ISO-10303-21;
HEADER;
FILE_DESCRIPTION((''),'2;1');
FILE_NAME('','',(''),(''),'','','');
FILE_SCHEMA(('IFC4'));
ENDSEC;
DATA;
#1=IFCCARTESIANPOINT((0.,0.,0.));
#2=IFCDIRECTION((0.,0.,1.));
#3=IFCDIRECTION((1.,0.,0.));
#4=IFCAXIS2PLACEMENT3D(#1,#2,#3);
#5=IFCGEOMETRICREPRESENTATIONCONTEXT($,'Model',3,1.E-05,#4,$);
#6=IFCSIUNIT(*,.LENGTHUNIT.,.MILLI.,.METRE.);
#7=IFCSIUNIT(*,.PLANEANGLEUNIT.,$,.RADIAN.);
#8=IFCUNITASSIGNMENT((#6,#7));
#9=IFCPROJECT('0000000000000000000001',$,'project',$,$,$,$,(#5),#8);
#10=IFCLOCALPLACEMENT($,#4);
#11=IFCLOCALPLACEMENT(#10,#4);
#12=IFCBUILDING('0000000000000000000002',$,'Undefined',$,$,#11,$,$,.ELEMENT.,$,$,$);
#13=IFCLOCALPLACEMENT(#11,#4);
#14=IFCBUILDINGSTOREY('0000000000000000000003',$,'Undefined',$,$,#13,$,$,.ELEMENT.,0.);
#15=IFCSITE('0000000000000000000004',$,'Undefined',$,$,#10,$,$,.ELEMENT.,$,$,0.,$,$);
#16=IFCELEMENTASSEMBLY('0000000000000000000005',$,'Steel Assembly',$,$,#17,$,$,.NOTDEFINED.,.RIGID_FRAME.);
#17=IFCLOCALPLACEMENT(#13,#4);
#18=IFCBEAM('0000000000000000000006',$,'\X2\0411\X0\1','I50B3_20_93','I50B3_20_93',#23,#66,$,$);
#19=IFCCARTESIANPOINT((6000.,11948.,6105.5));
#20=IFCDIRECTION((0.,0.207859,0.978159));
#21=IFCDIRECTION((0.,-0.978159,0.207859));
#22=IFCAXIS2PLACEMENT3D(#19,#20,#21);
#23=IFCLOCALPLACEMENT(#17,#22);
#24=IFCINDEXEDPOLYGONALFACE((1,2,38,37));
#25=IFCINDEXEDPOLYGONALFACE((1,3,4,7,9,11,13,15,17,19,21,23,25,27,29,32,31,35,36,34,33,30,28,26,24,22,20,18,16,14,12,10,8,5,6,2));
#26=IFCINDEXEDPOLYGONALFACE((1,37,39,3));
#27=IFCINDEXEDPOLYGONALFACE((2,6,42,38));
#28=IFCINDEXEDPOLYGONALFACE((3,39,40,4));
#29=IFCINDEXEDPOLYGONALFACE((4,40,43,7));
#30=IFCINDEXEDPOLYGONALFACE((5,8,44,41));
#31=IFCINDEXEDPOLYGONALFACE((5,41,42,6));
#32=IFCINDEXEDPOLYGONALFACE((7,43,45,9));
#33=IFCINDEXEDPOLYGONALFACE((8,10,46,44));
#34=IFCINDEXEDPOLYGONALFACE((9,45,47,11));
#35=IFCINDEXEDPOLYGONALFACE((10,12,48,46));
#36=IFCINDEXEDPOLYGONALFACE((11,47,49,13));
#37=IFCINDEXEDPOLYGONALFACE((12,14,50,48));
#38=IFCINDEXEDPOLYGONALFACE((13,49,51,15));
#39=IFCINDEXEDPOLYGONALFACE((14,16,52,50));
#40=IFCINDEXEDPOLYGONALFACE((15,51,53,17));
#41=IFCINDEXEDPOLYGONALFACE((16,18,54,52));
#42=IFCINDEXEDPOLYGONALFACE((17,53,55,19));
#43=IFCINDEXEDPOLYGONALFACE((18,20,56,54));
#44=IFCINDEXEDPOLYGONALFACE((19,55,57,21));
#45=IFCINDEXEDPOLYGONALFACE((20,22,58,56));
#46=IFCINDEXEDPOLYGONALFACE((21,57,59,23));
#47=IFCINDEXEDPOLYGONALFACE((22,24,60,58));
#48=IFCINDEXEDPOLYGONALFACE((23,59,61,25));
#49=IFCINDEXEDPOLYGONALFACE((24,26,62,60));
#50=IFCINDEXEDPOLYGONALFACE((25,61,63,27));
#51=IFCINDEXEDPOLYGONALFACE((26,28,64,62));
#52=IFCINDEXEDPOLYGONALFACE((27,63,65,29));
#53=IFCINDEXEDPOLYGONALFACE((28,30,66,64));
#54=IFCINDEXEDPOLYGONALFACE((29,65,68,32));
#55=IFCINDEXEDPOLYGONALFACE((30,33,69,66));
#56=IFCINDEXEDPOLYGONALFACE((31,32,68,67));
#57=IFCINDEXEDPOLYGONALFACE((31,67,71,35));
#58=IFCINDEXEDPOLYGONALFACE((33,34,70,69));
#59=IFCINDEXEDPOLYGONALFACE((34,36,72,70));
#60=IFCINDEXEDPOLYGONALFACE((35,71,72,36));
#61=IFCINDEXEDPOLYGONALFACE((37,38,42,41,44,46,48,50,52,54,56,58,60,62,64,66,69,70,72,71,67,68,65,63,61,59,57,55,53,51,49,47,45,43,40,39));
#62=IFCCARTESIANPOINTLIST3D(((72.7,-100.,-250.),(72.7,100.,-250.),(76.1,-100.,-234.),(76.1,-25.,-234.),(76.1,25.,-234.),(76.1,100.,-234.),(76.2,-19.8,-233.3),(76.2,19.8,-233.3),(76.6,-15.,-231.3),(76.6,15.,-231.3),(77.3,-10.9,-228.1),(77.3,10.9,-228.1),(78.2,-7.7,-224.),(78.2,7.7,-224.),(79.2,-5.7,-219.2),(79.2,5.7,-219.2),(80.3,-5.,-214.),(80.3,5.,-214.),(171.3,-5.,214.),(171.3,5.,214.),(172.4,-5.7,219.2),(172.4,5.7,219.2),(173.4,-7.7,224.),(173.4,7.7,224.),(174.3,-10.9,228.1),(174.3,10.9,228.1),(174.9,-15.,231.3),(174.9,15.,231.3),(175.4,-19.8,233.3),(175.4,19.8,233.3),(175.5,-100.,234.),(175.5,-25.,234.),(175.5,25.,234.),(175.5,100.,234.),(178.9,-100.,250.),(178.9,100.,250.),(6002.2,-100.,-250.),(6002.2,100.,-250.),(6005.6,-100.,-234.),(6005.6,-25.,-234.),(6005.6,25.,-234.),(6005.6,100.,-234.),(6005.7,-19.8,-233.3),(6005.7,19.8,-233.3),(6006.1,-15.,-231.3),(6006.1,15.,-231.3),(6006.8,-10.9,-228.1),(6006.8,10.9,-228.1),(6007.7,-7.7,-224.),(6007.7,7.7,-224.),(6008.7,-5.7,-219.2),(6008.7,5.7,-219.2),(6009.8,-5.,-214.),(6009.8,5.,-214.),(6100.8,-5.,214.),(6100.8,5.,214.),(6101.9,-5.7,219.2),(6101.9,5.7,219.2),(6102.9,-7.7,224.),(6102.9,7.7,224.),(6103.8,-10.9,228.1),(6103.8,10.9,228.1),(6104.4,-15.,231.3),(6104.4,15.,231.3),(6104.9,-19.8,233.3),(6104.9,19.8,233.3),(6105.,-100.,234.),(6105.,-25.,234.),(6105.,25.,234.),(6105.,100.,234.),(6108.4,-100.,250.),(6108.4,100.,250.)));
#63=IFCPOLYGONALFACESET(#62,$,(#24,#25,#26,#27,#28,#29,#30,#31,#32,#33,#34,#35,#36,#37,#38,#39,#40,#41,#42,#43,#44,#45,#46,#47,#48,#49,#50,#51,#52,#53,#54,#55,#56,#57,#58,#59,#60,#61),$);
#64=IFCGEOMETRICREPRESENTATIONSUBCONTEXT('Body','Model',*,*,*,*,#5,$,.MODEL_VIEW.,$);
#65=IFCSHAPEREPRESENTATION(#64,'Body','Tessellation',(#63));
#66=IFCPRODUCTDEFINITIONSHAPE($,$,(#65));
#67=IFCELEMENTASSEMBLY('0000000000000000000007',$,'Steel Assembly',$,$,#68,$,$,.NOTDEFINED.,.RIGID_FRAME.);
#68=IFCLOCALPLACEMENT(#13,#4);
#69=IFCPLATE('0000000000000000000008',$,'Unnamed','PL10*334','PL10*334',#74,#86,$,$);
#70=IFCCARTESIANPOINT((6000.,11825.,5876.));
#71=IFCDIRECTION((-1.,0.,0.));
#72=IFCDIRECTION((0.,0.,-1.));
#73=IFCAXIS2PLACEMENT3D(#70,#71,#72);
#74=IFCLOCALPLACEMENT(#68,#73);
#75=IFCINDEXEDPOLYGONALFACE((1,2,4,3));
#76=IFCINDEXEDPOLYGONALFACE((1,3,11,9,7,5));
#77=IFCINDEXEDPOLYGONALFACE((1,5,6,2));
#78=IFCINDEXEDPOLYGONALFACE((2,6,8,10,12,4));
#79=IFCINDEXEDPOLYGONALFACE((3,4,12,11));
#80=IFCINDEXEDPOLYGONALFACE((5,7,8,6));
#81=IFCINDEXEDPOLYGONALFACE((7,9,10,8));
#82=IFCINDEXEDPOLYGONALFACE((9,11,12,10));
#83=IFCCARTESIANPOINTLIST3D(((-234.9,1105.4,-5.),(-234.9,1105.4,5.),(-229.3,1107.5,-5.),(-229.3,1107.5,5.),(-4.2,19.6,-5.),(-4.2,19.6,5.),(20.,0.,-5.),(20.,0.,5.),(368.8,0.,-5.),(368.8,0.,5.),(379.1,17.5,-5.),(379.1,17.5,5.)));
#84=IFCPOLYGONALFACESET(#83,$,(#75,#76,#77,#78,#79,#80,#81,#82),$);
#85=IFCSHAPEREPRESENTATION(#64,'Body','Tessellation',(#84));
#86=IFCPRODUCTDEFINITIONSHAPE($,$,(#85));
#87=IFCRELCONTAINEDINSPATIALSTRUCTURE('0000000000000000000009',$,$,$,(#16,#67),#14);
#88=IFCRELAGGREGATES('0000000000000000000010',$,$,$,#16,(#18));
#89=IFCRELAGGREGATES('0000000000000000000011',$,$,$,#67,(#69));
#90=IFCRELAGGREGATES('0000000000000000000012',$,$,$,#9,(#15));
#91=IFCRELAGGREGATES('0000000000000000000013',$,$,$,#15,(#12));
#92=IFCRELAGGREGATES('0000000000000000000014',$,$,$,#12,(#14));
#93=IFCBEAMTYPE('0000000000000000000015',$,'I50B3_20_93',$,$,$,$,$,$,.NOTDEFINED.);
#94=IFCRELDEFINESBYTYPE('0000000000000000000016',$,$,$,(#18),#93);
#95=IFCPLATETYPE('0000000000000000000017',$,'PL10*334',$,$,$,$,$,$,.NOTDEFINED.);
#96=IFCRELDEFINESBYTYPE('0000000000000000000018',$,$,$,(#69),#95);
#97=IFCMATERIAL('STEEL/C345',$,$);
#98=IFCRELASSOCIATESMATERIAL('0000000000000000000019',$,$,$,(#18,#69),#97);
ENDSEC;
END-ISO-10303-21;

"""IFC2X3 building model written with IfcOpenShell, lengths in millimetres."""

from ifc_helpers import new_model, si_unit, frame, origin_with_axes, origin_2d_with_axis, place, context, subcontext, project, spatial, polyline, i_section, outline, extrude, clip, halfspace, material, type_object, element, aggregate, save


model = new_model("IFC2X3")

# Units and contexts
model_context = context("Model", 3, precision=1e-05, world=origin_with_axes())
body_context = subcontext(model_context, "Body", "Model", "MODEL_VIEW")
ifc_project = project(units=[si_unit("LENGTHUNIT", "METRE", prefix="MILLI"), si_unit("PLANEANGLEUNIT", "RADIAN")], contexts=[model_context])

# Site, building, storey
site_placement = place(None, origin_with_axes())
site = spatial("IfcSite", under=ifc_project, at=site_placement, Name="Undefined", CompositionType="ELEMENT", RefElevation=0.0)
building_placement = place(site_placement, origin_with_axes())
building = spatial("IfcBuilding", under=site, at=building_placement, Name="Undefined", CompositionType="ELEMENT")
storey_placement = place(building_placement, origin_with_axes())
storey = spatial("IfcBuildingStorey", under=building, at=storey_placement, Name="Undefined", CompositionType="ELEMENT", Elevation=0.0)

# Element assembly, beam
ifc_material_1 = material(Name="STEEL/C345")
assembly_1_placement = place(storey_placement, origin_with_axes())
assembly_1 = element("IfcElementAssembly", 1, at=assembly_1_placement, inside=storey, Name="Steel Assembly", AssemblyPlace="NOTDEFINED", PredefinedType="RIGID_FRAME")
beam_type_1 = type_object("IfcBeamType", Name="I50B3_20_93", PredefinedType="NOTDEFINED")
beam_1_placement = place(assembly_1_placement, frame((6000.0, 11948.0, 6105.5), z_axis=(0.0, 0.207859, 0.978159), x_axis=(0.0, -0.978159, 0.207859)))
beam_1 = element("IfcBeam", 2, at=beam_1_placement, type_object=beam_type_1, material=ifc_material_1, Name="Б1", Description="I50B3_20_93", ObjectType="I50B3_20_93", context=body_context, shape_type="Clipping", body=[
    clip(clip(extrude(i_section(OverallWidth=200.0, OverallDepth=500.0, WebThickness=10.0, FlangeThickness=16.0, FilletRadius=20.0, at=origin_2d_with_axis()), frame((6134.0, 0.0, 0.0), z_axis=(-1.0, 0.0, 0.0), x_axis=(0.0, -1.0, 0.0)), (0.0, 0.0, 1.0), 6134.0), halfspace(frame((-125.5, -110.0, -1182.5), z_axis=(-0.978159, 0.0, 0.207859), x_axis=(0.0, 1.0, 0.0)), False)), halfspace(frame((6109.5, -110.0, 255.2), z_axis=(0.978159, 0.0, -0.207859), x_axis=(0.0, 1.0, 0.0)), False)),
])
aggregate(assembly_1, [beam_1])

# Element assembly, plate
assembly_2_placement = place(storey_placement, origin_with_axes())
assembly_2 = element("IfcElementAssembly", 3, at=assembly_2_placement, inside=storey, Name="Steel Assembly", AssemblyPlace="NOTDEFINED", PredefinedType="RIGID_FRAME")
plate_type_1 = type_object("IfcPlateType", Name="PL10*334", PredefinedType="NOTDEFINED")
plate_1_placement = place(assembly_2_placement, frame((6000.0, 11825.0, 5876.0), z_axis=(-1.0, 0.0, 0.0), x_axis=(0.0, 0.0, -1.0)))
plate_1 = element("IfcPlate", 4, at=plate_1_placement, type_object=plate_type_1, material=ifc_material_1, Name="Unnamed", Description="PL10*334", ObjectType="PL10*334", context=body_context, shape_type="SweptSolid", body=[
    extrude(outline(polyline([(-4.2, 19.6), (20.0, 0.0), (368.8, 0.0), (379.1, 17.5), (-229.3, 1107.5), (-234.9, 1105.4), (-4.2, 19.6)])), frame((0.0, 0.0, -5.0), z_axis=(0.0, 0.0, 1.0), x_axis=(1.0, 0.0, 0.0)), (0.0, 0.0, 1.0), 10.0),
])
aggregate(assembly_2, [plate_1])

save(model, "model.ifc")
